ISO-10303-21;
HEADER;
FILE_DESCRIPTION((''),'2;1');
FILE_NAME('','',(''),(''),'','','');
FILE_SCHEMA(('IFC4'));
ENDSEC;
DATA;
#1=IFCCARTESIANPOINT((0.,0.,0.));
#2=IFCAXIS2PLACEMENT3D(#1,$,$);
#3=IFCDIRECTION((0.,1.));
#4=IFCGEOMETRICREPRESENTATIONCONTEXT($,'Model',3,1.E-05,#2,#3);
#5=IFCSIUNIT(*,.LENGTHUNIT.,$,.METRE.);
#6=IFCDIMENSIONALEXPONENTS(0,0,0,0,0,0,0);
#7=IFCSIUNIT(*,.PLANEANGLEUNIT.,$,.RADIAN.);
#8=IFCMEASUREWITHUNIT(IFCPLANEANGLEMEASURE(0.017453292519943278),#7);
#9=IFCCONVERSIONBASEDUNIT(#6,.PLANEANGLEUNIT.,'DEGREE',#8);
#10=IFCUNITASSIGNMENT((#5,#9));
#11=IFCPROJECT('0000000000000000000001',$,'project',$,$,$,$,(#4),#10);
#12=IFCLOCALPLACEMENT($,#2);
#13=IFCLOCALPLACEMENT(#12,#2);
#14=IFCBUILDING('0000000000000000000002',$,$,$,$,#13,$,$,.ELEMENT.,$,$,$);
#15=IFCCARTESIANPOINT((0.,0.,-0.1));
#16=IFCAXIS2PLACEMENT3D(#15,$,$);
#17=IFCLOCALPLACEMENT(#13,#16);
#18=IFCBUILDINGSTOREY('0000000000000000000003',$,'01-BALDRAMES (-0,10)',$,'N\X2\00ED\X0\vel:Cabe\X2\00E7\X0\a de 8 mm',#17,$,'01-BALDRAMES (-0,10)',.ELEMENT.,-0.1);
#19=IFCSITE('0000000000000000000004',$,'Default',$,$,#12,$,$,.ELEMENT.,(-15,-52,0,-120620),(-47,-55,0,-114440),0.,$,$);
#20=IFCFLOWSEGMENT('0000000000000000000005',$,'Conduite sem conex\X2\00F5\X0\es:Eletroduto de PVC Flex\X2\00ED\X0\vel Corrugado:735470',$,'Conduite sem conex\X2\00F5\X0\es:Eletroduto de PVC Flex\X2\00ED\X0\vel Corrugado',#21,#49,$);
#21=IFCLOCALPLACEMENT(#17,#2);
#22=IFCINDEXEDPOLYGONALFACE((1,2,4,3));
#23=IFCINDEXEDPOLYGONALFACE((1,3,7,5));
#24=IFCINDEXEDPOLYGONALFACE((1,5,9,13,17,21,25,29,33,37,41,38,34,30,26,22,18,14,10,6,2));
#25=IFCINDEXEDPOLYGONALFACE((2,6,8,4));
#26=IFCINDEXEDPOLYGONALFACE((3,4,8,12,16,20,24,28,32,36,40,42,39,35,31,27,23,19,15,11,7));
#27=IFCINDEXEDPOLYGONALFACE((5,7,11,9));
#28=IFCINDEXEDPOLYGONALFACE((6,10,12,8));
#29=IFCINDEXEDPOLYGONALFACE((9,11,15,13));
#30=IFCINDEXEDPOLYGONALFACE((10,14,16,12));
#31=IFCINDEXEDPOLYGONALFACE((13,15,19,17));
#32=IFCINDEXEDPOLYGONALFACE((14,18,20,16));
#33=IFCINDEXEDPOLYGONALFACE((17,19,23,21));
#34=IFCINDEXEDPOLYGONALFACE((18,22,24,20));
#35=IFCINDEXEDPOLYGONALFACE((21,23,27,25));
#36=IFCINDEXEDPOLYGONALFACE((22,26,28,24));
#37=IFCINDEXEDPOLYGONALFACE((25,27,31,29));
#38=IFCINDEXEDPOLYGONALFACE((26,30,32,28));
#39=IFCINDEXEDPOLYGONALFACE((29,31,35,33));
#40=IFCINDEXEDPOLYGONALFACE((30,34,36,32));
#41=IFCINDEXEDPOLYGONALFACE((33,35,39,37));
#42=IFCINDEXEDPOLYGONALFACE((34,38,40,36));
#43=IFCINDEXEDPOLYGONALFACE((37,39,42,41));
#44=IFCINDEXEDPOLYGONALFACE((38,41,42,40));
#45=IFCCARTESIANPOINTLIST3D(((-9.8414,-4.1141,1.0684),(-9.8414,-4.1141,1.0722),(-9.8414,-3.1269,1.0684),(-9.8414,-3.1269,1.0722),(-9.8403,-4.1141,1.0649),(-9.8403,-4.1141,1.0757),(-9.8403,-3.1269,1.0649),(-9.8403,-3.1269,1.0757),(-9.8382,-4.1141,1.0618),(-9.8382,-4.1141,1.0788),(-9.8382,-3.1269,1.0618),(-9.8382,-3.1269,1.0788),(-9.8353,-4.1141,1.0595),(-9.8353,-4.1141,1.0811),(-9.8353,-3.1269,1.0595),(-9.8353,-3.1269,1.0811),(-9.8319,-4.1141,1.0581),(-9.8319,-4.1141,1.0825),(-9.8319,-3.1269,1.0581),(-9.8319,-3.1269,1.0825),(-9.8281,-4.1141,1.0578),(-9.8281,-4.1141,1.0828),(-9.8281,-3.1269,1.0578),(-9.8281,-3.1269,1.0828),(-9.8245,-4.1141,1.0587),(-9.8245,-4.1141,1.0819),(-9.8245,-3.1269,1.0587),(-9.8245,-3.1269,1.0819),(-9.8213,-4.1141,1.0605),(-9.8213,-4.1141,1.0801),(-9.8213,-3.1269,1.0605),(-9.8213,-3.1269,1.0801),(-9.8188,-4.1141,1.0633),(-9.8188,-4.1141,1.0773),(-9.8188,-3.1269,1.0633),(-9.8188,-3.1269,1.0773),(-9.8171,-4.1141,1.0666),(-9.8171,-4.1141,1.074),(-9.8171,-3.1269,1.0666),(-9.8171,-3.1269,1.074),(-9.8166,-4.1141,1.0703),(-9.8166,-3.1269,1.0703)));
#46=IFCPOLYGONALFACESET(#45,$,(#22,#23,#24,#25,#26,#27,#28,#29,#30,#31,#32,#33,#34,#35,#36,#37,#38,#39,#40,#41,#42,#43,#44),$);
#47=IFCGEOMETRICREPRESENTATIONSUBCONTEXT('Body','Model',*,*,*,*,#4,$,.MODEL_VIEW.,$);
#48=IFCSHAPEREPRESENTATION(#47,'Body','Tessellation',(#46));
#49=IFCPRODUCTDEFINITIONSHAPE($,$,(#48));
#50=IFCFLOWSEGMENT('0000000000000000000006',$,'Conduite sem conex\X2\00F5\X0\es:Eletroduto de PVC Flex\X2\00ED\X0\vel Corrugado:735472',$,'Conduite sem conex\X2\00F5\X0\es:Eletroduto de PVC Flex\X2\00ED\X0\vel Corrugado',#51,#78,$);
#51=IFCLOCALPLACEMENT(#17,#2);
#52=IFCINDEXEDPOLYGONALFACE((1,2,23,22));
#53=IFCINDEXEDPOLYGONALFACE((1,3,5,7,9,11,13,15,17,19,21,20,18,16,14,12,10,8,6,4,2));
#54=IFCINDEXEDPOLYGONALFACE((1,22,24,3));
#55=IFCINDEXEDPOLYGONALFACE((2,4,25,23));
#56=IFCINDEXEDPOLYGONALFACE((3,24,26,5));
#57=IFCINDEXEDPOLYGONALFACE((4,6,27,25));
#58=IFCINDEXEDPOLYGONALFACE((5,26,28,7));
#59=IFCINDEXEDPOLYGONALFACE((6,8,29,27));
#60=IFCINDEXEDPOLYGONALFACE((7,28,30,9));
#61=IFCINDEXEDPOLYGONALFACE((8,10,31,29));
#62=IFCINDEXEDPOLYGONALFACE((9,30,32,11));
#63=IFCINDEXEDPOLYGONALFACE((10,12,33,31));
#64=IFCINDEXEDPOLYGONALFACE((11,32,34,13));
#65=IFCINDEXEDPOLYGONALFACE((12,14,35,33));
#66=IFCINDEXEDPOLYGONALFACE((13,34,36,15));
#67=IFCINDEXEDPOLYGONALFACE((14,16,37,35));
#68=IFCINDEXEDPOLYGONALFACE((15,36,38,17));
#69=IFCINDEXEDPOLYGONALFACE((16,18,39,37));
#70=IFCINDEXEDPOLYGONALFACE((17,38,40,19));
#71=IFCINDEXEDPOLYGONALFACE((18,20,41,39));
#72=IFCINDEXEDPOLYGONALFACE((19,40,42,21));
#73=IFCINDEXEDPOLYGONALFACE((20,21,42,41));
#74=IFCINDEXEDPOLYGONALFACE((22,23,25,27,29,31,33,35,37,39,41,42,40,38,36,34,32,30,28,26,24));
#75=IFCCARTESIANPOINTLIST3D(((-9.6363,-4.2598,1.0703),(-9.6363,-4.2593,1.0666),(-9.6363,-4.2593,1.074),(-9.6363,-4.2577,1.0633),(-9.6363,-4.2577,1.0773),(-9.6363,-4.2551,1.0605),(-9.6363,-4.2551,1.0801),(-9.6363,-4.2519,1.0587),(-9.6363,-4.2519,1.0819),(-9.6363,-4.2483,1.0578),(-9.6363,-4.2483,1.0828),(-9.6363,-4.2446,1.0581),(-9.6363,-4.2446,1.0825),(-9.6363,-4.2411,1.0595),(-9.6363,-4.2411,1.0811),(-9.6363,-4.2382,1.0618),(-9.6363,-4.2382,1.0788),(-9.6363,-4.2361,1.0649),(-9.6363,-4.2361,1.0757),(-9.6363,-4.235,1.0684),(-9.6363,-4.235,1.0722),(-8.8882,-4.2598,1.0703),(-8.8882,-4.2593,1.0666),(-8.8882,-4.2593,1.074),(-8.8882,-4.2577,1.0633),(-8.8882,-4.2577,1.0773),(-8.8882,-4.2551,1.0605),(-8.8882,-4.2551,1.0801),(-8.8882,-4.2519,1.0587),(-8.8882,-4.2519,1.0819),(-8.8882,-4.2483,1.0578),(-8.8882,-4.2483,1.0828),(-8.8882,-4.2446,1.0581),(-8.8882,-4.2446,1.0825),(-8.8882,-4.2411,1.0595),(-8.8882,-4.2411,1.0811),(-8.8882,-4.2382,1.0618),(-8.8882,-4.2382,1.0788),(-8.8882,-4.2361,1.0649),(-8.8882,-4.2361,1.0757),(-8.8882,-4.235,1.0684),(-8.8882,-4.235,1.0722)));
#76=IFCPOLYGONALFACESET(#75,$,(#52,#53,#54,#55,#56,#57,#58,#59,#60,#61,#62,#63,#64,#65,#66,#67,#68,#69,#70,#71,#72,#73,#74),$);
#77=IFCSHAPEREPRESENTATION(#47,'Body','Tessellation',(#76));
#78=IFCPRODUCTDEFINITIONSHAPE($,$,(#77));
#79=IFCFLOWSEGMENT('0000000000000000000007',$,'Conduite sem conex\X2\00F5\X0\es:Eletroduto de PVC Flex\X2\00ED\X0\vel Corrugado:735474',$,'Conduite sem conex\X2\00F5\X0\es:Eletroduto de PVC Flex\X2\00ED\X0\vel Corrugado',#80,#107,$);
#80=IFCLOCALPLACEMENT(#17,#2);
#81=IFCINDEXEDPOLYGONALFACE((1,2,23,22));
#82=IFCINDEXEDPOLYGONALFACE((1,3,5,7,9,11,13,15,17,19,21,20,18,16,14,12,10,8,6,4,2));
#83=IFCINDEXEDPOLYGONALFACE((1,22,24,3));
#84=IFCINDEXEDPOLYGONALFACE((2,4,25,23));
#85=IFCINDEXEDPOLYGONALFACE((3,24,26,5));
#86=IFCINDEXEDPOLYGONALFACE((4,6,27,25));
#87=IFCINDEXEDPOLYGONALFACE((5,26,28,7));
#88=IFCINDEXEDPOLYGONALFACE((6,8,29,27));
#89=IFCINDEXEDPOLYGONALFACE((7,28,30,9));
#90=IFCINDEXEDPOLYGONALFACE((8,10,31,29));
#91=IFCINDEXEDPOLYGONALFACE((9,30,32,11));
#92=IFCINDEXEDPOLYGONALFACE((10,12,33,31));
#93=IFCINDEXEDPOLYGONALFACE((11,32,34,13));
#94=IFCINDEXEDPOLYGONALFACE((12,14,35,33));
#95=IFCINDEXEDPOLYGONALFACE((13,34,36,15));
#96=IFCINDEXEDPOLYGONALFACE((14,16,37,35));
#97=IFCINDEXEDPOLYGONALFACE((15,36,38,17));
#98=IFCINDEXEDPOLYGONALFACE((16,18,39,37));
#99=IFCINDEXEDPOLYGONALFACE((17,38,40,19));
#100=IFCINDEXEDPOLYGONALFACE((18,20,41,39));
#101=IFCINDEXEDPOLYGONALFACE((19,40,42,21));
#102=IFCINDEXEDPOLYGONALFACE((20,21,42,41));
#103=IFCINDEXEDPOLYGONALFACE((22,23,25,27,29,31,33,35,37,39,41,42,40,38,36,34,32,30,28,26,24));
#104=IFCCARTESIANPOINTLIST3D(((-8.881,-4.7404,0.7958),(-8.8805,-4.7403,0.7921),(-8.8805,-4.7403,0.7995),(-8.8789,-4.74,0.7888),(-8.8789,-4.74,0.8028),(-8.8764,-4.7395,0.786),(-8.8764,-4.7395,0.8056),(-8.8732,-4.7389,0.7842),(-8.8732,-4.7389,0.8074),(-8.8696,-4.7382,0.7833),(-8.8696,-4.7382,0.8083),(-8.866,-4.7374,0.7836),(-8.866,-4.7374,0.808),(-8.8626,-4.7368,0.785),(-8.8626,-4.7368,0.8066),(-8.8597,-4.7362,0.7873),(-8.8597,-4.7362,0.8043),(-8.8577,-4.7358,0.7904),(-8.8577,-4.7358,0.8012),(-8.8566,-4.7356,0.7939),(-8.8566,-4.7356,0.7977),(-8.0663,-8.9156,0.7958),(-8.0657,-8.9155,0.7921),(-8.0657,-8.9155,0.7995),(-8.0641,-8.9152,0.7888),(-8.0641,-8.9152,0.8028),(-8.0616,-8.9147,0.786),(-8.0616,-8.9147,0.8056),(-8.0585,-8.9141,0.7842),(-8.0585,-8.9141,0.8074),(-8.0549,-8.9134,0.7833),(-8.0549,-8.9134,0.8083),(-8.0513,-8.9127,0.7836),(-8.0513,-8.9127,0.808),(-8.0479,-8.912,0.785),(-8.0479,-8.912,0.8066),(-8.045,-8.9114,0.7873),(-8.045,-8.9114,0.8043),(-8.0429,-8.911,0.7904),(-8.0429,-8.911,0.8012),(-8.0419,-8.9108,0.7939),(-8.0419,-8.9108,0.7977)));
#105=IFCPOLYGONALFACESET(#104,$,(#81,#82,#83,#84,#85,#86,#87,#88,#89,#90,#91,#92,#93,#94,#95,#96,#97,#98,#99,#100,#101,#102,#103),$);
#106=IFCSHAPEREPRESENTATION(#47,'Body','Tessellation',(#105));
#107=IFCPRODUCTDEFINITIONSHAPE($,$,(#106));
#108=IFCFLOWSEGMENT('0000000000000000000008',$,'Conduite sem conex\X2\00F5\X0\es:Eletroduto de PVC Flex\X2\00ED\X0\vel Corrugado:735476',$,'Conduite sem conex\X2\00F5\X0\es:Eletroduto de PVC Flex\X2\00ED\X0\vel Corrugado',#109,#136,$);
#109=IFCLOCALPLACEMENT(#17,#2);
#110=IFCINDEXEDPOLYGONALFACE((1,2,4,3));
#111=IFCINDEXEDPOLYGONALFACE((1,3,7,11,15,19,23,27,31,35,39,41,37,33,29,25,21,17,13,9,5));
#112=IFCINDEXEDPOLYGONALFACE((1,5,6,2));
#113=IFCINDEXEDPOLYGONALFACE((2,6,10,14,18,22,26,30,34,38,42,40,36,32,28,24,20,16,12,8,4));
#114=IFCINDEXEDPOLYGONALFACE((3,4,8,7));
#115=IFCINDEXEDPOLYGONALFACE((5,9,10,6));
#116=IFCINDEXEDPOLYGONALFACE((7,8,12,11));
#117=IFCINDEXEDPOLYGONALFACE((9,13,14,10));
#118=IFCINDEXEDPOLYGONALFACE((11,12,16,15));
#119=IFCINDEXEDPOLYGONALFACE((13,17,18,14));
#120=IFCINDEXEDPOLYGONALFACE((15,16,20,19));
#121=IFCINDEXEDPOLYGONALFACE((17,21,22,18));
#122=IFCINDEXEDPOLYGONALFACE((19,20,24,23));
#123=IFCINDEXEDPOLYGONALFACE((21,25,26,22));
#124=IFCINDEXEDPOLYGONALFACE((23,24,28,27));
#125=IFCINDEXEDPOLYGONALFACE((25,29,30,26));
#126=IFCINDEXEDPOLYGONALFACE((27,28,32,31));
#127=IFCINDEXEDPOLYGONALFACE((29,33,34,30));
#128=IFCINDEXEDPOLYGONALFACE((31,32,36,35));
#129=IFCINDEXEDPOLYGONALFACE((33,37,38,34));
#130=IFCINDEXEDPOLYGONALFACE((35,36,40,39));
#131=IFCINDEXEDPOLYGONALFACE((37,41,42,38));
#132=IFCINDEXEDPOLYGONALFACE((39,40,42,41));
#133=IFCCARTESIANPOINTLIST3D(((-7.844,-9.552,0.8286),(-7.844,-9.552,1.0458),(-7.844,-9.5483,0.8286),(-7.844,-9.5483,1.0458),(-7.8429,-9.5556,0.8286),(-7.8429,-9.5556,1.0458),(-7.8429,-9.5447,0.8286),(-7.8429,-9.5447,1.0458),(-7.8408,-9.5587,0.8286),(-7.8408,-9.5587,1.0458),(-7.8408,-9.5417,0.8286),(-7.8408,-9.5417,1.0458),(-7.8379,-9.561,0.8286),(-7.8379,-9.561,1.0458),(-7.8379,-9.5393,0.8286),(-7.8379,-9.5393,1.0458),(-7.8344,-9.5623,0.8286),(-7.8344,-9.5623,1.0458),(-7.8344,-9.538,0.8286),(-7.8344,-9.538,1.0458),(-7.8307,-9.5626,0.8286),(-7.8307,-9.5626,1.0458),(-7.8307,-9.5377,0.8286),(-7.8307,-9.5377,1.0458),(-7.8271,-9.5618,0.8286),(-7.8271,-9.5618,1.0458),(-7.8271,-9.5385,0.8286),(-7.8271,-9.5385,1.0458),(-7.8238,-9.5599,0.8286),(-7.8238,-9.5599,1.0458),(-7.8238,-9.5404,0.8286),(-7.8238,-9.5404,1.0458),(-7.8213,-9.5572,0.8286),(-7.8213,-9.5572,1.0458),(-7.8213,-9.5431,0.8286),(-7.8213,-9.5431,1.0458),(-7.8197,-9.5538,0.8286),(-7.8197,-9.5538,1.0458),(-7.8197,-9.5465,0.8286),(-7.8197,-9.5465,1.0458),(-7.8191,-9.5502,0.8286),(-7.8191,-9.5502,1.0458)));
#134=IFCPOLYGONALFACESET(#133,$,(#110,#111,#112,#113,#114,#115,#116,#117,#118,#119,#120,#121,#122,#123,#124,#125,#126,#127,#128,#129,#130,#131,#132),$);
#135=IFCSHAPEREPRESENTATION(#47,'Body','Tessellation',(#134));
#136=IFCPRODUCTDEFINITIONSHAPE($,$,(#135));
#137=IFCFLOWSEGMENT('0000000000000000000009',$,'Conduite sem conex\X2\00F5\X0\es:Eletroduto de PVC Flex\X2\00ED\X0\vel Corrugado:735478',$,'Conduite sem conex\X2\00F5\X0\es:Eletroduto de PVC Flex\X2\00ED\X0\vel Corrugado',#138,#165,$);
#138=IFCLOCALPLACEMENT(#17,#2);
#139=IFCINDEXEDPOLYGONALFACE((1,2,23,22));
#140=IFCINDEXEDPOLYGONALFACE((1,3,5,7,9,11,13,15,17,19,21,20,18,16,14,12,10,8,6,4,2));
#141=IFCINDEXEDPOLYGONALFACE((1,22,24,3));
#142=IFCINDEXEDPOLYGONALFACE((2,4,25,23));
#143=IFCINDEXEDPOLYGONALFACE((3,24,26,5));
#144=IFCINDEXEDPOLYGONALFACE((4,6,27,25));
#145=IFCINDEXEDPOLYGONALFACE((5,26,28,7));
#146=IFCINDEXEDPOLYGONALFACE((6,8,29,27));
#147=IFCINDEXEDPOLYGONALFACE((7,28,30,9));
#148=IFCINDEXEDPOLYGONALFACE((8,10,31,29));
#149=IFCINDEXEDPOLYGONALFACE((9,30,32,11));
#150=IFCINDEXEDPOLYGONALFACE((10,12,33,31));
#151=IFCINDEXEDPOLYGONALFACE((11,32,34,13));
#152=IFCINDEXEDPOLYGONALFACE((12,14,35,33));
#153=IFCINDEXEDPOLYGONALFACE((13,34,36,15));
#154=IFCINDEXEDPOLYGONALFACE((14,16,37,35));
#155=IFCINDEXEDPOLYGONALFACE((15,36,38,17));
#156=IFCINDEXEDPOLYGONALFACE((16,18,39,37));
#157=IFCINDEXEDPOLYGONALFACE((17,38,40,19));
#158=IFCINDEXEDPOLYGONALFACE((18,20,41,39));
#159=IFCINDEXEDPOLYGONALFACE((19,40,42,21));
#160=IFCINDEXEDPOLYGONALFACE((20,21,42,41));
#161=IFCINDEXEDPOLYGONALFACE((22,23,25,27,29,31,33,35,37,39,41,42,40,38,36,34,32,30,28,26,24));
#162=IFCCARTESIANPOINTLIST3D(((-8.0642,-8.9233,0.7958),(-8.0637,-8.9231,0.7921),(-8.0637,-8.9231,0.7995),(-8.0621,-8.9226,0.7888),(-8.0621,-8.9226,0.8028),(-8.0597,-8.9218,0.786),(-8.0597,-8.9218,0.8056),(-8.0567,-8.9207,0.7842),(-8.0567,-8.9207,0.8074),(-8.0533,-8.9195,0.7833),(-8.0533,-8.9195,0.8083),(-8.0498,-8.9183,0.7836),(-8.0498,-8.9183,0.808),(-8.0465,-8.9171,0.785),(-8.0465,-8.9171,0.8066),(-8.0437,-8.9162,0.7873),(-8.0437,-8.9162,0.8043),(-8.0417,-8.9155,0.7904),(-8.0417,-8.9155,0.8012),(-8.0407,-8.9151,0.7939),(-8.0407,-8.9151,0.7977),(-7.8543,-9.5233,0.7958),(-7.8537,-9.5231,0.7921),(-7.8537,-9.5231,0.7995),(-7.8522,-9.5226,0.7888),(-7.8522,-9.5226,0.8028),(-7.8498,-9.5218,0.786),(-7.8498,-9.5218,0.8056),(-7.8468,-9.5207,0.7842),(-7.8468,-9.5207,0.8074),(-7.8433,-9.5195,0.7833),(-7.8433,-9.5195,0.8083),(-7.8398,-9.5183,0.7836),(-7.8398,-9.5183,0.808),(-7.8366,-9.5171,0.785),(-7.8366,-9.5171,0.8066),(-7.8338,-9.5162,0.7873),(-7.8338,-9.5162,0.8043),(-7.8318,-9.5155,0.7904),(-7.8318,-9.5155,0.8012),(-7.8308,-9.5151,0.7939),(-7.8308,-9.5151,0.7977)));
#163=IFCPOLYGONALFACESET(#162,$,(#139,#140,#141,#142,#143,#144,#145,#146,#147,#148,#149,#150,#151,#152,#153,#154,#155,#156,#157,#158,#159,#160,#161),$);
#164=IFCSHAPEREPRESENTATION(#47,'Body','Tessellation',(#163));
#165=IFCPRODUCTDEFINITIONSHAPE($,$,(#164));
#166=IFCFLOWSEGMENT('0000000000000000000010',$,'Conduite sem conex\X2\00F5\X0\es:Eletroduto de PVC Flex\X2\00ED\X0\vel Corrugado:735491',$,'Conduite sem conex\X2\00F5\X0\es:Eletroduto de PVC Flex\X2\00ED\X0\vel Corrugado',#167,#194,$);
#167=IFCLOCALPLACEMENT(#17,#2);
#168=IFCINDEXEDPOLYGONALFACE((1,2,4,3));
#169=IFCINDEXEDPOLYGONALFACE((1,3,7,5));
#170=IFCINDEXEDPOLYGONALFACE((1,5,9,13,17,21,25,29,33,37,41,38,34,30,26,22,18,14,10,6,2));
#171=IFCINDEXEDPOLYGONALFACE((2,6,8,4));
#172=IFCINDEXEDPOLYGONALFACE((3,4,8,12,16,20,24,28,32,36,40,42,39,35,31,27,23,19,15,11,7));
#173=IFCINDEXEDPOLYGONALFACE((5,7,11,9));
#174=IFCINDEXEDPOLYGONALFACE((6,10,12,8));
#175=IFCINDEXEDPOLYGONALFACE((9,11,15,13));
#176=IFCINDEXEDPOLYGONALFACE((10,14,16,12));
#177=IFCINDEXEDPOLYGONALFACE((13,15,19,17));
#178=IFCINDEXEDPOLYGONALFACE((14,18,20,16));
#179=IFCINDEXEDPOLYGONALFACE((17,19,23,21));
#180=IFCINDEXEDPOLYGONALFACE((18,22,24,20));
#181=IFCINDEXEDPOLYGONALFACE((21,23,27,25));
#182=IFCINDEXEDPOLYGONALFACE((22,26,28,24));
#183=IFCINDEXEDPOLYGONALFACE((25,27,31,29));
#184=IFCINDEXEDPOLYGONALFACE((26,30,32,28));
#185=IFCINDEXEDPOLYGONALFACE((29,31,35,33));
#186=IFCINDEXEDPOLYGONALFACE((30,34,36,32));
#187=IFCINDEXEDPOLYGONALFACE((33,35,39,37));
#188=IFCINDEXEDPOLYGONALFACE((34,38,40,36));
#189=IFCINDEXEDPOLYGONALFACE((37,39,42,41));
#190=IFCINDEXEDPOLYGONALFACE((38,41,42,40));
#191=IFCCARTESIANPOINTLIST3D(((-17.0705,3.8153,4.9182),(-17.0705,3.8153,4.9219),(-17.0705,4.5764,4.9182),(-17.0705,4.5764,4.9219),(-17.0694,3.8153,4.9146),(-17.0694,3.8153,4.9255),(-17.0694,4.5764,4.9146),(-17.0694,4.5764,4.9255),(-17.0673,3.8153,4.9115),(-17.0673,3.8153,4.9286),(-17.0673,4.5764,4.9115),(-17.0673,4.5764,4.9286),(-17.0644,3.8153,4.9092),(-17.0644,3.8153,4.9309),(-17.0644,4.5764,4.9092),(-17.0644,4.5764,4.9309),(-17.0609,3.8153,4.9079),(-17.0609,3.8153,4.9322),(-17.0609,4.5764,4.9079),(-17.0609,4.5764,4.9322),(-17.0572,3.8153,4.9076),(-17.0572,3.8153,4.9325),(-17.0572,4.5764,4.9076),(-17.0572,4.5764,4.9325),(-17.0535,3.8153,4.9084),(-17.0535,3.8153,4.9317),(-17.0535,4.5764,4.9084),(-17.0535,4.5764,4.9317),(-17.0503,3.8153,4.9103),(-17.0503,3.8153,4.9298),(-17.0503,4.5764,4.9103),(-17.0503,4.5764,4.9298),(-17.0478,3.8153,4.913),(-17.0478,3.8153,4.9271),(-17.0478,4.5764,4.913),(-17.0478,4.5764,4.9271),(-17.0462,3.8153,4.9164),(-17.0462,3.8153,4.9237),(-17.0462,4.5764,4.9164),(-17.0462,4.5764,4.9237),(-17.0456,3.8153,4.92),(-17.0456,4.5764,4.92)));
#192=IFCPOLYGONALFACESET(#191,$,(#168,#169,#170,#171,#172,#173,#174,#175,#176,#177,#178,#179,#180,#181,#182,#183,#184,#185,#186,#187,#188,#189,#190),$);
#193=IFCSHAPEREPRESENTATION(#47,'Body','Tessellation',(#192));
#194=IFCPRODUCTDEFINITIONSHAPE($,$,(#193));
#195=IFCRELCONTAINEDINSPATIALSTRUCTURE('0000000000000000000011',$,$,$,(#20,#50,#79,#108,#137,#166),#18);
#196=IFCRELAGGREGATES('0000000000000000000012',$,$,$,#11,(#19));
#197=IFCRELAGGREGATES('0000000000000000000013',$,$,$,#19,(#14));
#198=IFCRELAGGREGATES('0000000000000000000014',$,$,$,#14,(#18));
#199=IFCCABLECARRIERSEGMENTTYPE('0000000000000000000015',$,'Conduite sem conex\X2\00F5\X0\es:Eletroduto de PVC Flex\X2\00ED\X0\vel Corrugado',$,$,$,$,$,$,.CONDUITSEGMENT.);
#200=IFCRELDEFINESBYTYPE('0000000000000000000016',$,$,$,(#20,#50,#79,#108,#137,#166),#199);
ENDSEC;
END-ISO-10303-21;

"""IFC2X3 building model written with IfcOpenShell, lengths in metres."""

from ifc_helpers import new_model, entity, si_unit, converted_unit, direction, frame, frame_2d, origin, origin_2d_with_axis, place, context, subcontext, project, spatial, circle, extrude, type_object, element, save


model = new_model("IFC2X3")

# Units and contexts
model_context = context("Model", 3, precision=1e-05, world=origin(), true_north=direction((0.0, 1.0)))
body_context = subcontext(model_context, "Body", "Model", "MODEL_VIEW")
ifc_project = project(units=[si_unit("LENGTHUNIT", "METRE"), converted_unit("PLANEANGLEUNIT", "DEGREE", entity("IfcPlaneAngleMeasure", 0.017453292519943278), si_unit("PLANEANGLEUNIT", "RADIAN"), dimensions=[0, 0, 0, 0, 0, 0, 0])], contexts=[model_context])

# Site, building, storey
site_placement = place(None, origin())
site = spatial("IfcSite", under=ifc_project, at=site_placement, Name="Default", CompositionType="ELEMENT", RefLatitude=(-15, -52, 0, -120620), RefLongitude=(-47, -55, 0, -114440), RefElevation=0.0)
building_placement = place(site_placement, origin())
building = spatial("IfcBuilding", under=site, at=building_placement, CompositionType="ELEMENT")
storey_placement = place(building_placement, frame((0.0, 0.0, -0.1)))
storey = spatial("IfcBuildingStorey", under=building, at=storey_placement, Name="01-BALDRAMES (-0,10)", ObjectType="Nível:Cabeça de 8 mm", LongName="01-BALDRAMES (-0,10)", CompositionType="ELEMENT", Elevation=-0.1)

# Flow segments
cable_carrier_segment_type = type_object("IfcCableCarrierSegmentType", Name="Conduite sem conexões:Eletroduto de PVC Flexível Corrugado", PredefinedType="CONDUITSEGMENT")
flow_segment_1_placement = place(storey_placement, origin())
element("IfcFlowSegment", 1, at=flow_segment_1_placement, inside=storey, type_object=cable_carrier_segment_type, Name="Conduite sem conexões:Eletroduto de PVC Flexível Corrugado:735470", ObjectType="Conduite sem conexões:Eletroduto de PVC Flexível Corrugado", context=body_context, shape_type="SweptSolid", body=[
    extrude(circle(Radius=0.0125, at=origin_2d_with_axis()), frame((-9.8291, -4.1141, 1.0703), z_axis=(0.000001, 1.0, 0.0), x_axis=(1.0, -0.000001, 0.0)), (0.0, 0.0, 1.0), 0.9872),
])
flow_segment_2_placement = place(storey_placement, origin())
element("IfcFlowSegment", 2, at=flow_segment_2_placement, inside=storey, type_object=cable_carrier_segment_type, Name="Conduite sem conexões:Eletroduto de PVC Flexível Corrugado:735472", ObjectType="Conduite sem conexões:Eletroduto de PVC Flexível Corrugado", context=body_context, shape_type="SweptSolid", body=[
    extrude(circle(Radius=0.0125, at=frame_2d((0.0, 0.0), x_axis=(1.0, 0.0))), frame((-9.6363, -4.2473, 1.0703), z_axis=(1.0, 0.0, 0.0), x_axis=(0.0, -1.0, 0.0)), (0.0, 0.0, 1.0), 0.7481),
])
flow_segment_3_placement = place(storey_placement, origin())
element("IfcFlowSegment", 3, at=flow_segment_3_placement, inside=storey, type_object=cable_carrier_segment_type, Name="Conduite sem conexões:Eletroduto de PVC Flexível Corrugado:735474", ObjectType="Conduite sem conexões:Eletroduto de PVC Flexível Corrugado", context=body_context, shape_type="SweptSolid", body=[
    extrude(circle(Radius=0.0125, at=frame_2d((0.0, 0.0), x_axis=(1.0, 0.0))), frame((-8.8687, -4.738, 0.7958), z_axis=(0.191523, -0.981488, 0.0), x_axis=(-0.981488, -0.191523, 0.0)), (0.0, 0.0, 1.0), 4.254),
])
flow_segment_4_placement = place(storey_placement, origin())
element("IfcFlowSegment", 4, at=flow_segment_4_placement, inside=storey, type_object=cable_carrier_segment_type, Name="Conduite sem conexões:Eletroduto de PVC Flexível Corrugado:735476", ObjectType="Conduite sem conexões:Eletroduto de PVC Flexível Corrugado", context=body_context, shape_type="SweptSolid", body=[
    extrude(circle(Radius=0.0125, at=frame_2d((0.0, 0.0), x_axis=(1.0, 0.0))), frame((-7.8316, -9.5502, 0.8286)), (0.0, 0.0, 1.0), 0.2172),
])
flow_segment_5_placement = place(storey_placement, origin())
element("IfcFlowSegment", 5, at=flow_segment_5_placement, inside=storey, type_object=cable_carrier_segment_type, Name="Conduite sem conexões:Eletroduto de PVC Flexível Corrugado:735478", ObjectType="Conduite sem conexões:Eletroduto de PVC Flexível Corrugado", context=body_context, shape_type="SweptSolid", body=[
    extrude(circle(Radius=0.0125, at=frame_2d((0.0, 0.0), x_axis=(1.0, 0.0))), frame((-8.0524, -8.9192, 0.7958), z_axis=(0.330227, -0.943901, 0.0), x_axis=(-0.943901, -0.330227, 0.0)), (0.0, 0.0, 1.0), 0.6357),
])
flow_segment_6_placement = place(storey_placement, origin())
element("IfcFlowSegment", 6, at=flow_segment_6_placement, inside=storey, type_object=cable_carrier_segment_type, Name="Conduite sem conexões:Eletroduto de PVC Flexível Corrugado:735491", ObjectType="Conduite sem conexões:Eletroduto de PVC Flexível Corrugado", context=body_context, shape_type="SweptSolid", body=[
    extrude(circle(Radius=0.0125, at=origin_2d_with_axis()), frame((-17.0581, 3.8153, 4.92), z_axis=(0.0, 1.0, 0.0), x_axis=(1.0, 0.0, 0.0)), (0.0, 0.0, 1.0), 0.761),
])

save(model, "model.ifc")
